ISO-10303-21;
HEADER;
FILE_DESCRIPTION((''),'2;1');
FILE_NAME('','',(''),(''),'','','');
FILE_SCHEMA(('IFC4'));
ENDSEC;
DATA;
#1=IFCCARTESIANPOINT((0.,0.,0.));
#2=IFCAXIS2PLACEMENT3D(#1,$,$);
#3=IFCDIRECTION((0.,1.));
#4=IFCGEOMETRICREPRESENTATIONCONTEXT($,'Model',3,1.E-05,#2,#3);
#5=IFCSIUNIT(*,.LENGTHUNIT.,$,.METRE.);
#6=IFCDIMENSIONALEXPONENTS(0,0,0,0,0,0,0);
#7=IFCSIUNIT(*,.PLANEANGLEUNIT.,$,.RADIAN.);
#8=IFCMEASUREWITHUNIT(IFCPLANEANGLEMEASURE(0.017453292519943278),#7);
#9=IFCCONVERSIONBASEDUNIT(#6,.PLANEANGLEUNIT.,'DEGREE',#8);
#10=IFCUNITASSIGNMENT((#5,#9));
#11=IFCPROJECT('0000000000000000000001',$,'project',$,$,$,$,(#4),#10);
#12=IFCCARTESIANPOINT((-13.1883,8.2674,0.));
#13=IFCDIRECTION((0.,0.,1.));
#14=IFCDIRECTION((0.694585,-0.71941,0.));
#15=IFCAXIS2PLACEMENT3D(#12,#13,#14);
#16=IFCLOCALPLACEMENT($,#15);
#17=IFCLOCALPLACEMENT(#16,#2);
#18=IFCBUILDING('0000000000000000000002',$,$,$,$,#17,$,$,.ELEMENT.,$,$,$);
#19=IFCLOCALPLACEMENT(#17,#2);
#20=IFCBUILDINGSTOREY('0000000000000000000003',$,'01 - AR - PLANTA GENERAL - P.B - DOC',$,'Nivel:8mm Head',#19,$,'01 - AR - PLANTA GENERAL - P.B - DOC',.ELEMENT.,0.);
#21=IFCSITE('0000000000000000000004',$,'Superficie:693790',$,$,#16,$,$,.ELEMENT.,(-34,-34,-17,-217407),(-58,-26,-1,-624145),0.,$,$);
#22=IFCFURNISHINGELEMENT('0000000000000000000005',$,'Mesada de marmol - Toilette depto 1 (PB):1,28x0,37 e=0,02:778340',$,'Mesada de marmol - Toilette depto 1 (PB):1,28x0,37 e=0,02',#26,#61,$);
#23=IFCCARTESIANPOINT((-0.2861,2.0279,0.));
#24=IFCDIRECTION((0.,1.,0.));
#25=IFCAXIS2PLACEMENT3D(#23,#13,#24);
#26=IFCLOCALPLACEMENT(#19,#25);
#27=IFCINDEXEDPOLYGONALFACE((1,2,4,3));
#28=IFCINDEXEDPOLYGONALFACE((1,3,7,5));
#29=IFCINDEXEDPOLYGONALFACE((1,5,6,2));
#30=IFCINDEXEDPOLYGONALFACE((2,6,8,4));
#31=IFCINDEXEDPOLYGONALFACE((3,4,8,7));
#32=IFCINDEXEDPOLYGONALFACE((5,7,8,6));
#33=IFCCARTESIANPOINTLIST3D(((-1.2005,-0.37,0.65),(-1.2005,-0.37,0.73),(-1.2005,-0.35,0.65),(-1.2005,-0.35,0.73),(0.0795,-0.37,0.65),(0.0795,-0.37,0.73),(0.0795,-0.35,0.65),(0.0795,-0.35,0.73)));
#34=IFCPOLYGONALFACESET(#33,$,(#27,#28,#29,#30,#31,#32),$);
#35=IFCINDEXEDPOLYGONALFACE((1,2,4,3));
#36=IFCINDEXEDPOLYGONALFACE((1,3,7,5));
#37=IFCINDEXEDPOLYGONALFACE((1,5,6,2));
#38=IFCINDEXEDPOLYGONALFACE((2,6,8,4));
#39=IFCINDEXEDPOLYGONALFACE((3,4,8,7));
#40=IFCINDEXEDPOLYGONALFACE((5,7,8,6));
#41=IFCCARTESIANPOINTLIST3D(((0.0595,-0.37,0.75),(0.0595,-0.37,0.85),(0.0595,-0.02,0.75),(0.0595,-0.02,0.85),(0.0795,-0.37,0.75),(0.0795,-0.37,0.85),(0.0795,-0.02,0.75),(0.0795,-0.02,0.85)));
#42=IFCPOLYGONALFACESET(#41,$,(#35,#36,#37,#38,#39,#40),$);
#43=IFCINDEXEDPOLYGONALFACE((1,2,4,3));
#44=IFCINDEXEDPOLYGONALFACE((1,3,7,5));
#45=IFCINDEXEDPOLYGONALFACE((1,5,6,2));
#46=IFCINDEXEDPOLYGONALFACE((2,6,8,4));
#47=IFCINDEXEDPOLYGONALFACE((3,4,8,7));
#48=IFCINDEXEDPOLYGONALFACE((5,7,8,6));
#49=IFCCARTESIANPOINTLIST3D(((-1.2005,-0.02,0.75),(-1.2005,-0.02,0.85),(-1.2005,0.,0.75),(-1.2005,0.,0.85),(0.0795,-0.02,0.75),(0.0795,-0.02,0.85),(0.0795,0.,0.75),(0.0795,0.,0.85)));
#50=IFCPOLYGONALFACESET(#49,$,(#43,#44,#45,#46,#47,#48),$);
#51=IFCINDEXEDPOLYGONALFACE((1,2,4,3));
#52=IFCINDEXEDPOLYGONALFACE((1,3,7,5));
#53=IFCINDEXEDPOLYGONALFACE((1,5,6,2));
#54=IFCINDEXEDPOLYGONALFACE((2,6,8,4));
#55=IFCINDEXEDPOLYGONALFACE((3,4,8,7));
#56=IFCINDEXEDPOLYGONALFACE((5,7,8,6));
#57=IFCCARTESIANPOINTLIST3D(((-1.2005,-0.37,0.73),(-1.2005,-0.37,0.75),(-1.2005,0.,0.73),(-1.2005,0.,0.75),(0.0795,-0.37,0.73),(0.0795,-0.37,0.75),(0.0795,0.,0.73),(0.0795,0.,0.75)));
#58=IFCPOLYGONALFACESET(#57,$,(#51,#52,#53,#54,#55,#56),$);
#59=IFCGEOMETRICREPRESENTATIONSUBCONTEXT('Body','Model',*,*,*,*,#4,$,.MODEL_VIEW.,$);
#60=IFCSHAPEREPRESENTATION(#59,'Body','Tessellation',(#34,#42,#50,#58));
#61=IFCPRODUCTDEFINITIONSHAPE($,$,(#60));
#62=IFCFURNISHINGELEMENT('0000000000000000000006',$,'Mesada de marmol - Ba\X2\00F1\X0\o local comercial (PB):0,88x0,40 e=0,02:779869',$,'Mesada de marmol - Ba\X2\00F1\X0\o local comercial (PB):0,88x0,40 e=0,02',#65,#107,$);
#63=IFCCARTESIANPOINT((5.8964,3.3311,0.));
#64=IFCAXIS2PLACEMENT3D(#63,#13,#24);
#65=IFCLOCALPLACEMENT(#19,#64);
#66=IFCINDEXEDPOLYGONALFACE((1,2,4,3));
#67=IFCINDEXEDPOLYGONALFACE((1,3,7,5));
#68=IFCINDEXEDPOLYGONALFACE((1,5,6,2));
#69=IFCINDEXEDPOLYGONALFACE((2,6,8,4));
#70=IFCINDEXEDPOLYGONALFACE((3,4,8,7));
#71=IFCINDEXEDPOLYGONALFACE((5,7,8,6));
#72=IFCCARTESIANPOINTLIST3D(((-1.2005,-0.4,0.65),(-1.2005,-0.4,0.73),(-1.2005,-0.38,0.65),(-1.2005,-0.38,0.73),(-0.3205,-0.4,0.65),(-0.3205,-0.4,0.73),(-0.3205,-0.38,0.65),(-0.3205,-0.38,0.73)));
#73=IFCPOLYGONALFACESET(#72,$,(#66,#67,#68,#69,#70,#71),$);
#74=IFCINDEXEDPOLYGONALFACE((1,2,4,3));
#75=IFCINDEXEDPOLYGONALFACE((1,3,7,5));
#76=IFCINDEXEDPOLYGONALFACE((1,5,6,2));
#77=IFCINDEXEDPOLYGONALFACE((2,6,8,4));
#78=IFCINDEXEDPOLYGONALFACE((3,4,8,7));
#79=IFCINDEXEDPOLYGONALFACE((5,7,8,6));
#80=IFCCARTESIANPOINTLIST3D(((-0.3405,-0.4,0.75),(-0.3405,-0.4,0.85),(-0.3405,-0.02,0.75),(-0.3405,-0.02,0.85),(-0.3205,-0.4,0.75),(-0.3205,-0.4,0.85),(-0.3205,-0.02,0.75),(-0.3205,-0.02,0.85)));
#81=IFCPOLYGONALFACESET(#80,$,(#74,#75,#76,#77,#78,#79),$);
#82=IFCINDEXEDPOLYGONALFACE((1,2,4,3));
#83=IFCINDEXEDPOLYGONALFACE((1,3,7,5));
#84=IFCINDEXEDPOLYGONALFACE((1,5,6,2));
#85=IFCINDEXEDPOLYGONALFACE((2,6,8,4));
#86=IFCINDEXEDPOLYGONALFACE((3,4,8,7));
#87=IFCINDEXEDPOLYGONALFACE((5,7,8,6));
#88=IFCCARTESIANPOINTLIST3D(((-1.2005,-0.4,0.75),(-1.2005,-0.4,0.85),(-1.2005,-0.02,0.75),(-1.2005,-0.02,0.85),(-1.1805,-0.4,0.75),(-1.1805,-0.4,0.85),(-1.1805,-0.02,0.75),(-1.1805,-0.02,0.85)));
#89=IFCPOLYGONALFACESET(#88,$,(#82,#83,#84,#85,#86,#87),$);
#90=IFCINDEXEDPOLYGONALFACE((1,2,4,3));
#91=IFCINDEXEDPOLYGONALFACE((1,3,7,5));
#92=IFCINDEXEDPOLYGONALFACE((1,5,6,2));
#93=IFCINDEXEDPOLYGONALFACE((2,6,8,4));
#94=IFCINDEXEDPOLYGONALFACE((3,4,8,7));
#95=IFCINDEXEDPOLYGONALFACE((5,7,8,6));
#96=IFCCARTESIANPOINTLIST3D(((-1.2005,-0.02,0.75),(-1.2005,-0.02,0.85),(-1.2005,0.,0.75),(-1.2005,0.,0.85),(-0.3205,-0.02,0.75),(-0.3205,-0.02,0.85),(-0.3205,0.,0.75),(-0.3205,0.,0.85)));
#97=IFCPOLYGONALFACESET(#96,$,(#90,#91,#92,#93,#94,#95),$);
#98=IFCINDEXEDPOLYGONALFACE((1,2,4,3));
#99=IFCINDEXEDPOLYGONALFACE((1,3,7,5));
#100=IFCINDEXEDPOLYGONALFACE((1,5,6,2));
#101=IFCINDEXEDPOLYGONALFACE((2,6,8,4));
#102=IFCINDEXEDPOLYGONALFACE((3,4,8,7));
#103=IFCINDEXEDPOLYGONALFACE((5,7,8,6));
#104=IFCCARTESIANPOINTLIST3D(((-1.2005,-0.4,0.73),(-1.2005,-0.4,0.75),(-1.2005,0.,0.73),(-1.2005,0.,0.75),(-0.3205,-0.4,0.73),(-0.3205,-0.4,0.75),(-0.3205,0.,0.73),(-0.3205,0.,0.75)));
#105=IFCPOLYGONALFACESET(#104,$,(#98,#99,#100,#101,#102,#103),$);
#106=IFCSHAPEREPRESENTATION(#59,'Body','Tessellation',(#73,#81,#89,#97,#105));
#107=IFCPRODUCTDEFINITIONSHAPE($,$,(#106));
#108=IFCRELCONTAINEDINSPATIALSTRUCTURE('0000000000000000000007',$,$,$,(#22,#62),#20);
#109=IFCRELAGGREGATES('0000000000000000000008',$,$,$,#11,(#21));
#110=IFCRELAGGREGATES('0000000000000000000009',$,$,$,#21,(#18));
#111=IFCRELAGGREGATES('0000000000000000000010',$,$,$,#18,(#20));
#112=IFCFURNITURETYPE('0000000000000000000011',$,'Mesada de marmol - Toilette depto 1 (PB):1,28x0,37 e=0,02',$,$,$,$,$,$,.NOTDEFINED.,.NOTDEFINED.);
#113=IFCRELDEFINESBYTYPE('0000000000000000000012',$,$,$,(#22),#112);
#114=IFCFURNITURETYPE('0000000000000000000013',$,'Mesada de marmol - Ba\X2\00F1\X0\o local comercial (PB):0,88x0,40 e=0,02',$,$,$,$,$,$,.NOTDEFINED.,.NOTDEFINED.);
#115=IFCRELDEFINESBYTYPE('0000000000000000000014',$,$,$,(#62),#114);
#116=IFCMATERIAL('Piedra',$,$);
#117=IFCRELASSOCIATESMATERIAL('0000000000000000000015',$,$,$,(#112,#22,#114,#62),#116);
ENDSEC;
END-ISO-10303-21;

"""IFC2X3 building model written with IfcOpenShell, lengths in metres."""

from ifc_helpers import new_model, entity, si_unit, converted_unit, direction, frame, frame_2d, origin, origin_2d_with_axis, place, context, subcontext, project, spatial, rectangle, extrude, source, transform, mapped, material, type_object, type_shapes, element, save


model = new_model("IFC2X3")

# Units and contexts
model_context = context("Model", 3, precision=1e-05, world=origin(), true_north=direction((0.0, 1.0)))
body_context = subcontext(model_context, "Body", "Model", "MODEL_VIEW")
ifc_project = project(units=[si_unit("LENGTHUNIT", "METRE"), converted_unit("PLANEANGLEUNIT", "DEGREE", entity("IfcPlaneAngleMeasure", 0.017453292519943278), si_unit("PLANEANGLEUNIT", "RADIAN"), dimensions=[0, 0, 0, 0, 0, 0, 0])], contexts=[model_context])

# Site, building, storey
site_placement = place(None, frame((-13.1883, 8.2674, 0.0), z_axis=(0.0, 0.0, 1.0), x_axis=(0.694585, -0.71941, 0.0)))
site = spatial("IfcSite", under=ifc_project, at=site_placement, Name="Superficie:693790", CompositionType="ELEMENT", RefLatitude=(-34, -34, -17, -217407), RefLongitude=(-58, -26, -1, -624145), RefElevation=0.0)
building_placement = place(site_placement, origin())
building = spatial("IfcBuilding", under=site, at=building_placement, CompositionType="ELEMENT")
storey_placement = place(building_placement, origin())
storey = spatial("IfcBuildingStorey", under=building, at=storey_placement, Name="01 - AR - PLANTA GENERAL - P.B - DOC", ObjectType="Nivel:8mm Head", LongName="01 - AR - PLANTA GENERAL - P.B - DOC", CompositionType="ELEMENT", Elevation=0.0)

# Furnishing elements
ifc_material_1 = material(Name="Piedra")
furniture_type_1 = type_object("IfcFurnitureType", Name="Mesada de marmol - Toilette depto 1 (PB):1,28x0,37 e=0,02", AssemblyPlace="NOTDEFINED", material=ifc_material_1)
shared_shape_1 = source(origin(), body_context, "Body", "SweptSolid", [
    extrude(rectangle(XDim=0.02, YDim=1.28, at=origin_2d_with_axis()), frame((-0.5605, -0.36, 0.65), z_axis=(0.0, 0.0, 1.0), x_axis=(0.0, 1.0, 0.0)), (0.0, 0.0, 1.0), 0.08),
    extrude(rectangle(XDim=0.02, YDim=0.35, at=frame_2d((0.0, 0.0), x_axis=(1.0, 0.0))), frame((0.0695, -0.195, 0.75), z_axis=(0.0, 0.0, 1.0), x_axis=(-1.0, 0.0, 0.0)), (0.0, 0.0, 1.0), 0.1),
    extrude(rectangle(XDim=0.02, YDim=1.28, at=origin_2d_with_axis()), frame((-0.5605, -0.01, 0.75), z_axis=(0.0, 0.0, 1.0), x_axis=(0.0, -1.0, 0.0)), (0.0, 0.0, 1.0), 0.1),
    extrude(rectangle(XDim=1.28, YDim=0.37, at=frame_2d((0.0, 0.0), x_axis=(1.0, 0.0))), frame((-0.5605, -0.185, 0.73), z_axis=(0.0, 0.0, 1.0), x_axis=(-1.0, 0.0, 0.0)), (0.0, 0.0, 1.0), 0.02),
])
type_shapes(furniture_type_1, [shared_shape_1])
furnishing_1_placement = place(storey_placement, frame((-0.2861, 2.0279, 0.0), z_axis=(0.0, 0.0, 1.0), x_axis=(0.0, 1.0, 0.0)))
element("IfcFurnishingElement", 1, at=furnishing_1_placement, inside=storey, type_object=furniture_type_1, material=ifc_material_1, Name="Mesada de marmol - Toilette depto 1 (PB):1,28x0,37 e=0,02:778340", ObjectType="Mesada de marmol - Toilette depto 1 (PB):1,28x0,37 e=0,02", context=body_context, shape_type="MappedRepresentation", body=[
    mapped(shared_shape_1, transform((0.0, 0.0, 0.0), scale=1.0)),
])
furniture_type_2 = type_object("IfcFurnitureType", Name="Mesada de marmol - Baño local comercial (PB):0,88x0,40 e=0,02", AssemblyPlace="NOTDEFINED", material=ifc_material_1)
shared_shape_2 = source(origin(), body_context, "Body", "SweptSolid", [
    extrude(rectangle(XDim=0.02, YDim=0.88, at=frame_2d((0.0, 0.0), x_axis=(1.0, 0.0))), frame((-0.7605, -0.39, 0.65), z_axis=(0.0, 0.0, 1.0), x_axis=(0.0, 1.0, 0.0)), (0.0, 0.0, 1.0), 0.08),
    extrude(rectangle(XDim=0.38, YDim=0.02, at=origin_2d_with_axis()), frame((-0.3305, -0.21, 0.75), z_axis=(0.0, 0.0, 1.0), x_axis=(0.0, 1.0, 0.0)), (0.0, 0.0, 1.0), 0.1),
    extrude(rectangle(XDim=0.02, YDim=0.38, at=origin_2d_with_axis()), frame((-1.1905, -0.21, 0.75), z_axis=(0.0, 0.0, 1.0), x_axis=(-1.0, 0.0, 0.0)), (0.0, 0.0, 1.0), 0.1),
    extrude(rectangle(XDim=0.02, YDim=0.88, at=origin_2d_with_axis()), frame((-0.7605, -0.01, 0.75), z_axis=(0.0, 0.0, 1.0), x_axis=(0.0, -1.0, 0.0)), (0.0, 0.0, 1.0), 0.1),
    extrude(rectangle(XDim=0.88, YDim=0.4, at=origin_2d_with_axis()), frame((-0.7605, -0.2, 0.73), z_axis=(0.0, 0.0, 1.0), x_axis=(-1.0, 0.0, 0.0)), (0.0, 0.0, 1.0), 0.02),
])
type_shapes(furniture_type_2, [shared_shape_2])
furnishing_2_placement = place(storey_placement, frame((5.8964, 3.3311, 0.0), z_axis=(0.0, 0.0, 1.0), x_axis=(0.0, 1.0, 0.0)))
element("IfcFurnishingElement", 2, at=furnishing_2_placement, inside=storey, type_object=furniture_type_2, material=ifc_material_1, Name="Mesada de marmol - Baño local comercial (PB):0,88x0,40 e=0,02:779869", ObjectType="Mesada de marmol - Baño local comercial (PB):0,88x0,40 e=0,02", context=body_context, shape_type="MappedRepresentation", body=[
    mapped(shared_shape_2, transform((0.0, 0.0, 0.0), scale=1.0)),
])

save(model, "model.ifc")
